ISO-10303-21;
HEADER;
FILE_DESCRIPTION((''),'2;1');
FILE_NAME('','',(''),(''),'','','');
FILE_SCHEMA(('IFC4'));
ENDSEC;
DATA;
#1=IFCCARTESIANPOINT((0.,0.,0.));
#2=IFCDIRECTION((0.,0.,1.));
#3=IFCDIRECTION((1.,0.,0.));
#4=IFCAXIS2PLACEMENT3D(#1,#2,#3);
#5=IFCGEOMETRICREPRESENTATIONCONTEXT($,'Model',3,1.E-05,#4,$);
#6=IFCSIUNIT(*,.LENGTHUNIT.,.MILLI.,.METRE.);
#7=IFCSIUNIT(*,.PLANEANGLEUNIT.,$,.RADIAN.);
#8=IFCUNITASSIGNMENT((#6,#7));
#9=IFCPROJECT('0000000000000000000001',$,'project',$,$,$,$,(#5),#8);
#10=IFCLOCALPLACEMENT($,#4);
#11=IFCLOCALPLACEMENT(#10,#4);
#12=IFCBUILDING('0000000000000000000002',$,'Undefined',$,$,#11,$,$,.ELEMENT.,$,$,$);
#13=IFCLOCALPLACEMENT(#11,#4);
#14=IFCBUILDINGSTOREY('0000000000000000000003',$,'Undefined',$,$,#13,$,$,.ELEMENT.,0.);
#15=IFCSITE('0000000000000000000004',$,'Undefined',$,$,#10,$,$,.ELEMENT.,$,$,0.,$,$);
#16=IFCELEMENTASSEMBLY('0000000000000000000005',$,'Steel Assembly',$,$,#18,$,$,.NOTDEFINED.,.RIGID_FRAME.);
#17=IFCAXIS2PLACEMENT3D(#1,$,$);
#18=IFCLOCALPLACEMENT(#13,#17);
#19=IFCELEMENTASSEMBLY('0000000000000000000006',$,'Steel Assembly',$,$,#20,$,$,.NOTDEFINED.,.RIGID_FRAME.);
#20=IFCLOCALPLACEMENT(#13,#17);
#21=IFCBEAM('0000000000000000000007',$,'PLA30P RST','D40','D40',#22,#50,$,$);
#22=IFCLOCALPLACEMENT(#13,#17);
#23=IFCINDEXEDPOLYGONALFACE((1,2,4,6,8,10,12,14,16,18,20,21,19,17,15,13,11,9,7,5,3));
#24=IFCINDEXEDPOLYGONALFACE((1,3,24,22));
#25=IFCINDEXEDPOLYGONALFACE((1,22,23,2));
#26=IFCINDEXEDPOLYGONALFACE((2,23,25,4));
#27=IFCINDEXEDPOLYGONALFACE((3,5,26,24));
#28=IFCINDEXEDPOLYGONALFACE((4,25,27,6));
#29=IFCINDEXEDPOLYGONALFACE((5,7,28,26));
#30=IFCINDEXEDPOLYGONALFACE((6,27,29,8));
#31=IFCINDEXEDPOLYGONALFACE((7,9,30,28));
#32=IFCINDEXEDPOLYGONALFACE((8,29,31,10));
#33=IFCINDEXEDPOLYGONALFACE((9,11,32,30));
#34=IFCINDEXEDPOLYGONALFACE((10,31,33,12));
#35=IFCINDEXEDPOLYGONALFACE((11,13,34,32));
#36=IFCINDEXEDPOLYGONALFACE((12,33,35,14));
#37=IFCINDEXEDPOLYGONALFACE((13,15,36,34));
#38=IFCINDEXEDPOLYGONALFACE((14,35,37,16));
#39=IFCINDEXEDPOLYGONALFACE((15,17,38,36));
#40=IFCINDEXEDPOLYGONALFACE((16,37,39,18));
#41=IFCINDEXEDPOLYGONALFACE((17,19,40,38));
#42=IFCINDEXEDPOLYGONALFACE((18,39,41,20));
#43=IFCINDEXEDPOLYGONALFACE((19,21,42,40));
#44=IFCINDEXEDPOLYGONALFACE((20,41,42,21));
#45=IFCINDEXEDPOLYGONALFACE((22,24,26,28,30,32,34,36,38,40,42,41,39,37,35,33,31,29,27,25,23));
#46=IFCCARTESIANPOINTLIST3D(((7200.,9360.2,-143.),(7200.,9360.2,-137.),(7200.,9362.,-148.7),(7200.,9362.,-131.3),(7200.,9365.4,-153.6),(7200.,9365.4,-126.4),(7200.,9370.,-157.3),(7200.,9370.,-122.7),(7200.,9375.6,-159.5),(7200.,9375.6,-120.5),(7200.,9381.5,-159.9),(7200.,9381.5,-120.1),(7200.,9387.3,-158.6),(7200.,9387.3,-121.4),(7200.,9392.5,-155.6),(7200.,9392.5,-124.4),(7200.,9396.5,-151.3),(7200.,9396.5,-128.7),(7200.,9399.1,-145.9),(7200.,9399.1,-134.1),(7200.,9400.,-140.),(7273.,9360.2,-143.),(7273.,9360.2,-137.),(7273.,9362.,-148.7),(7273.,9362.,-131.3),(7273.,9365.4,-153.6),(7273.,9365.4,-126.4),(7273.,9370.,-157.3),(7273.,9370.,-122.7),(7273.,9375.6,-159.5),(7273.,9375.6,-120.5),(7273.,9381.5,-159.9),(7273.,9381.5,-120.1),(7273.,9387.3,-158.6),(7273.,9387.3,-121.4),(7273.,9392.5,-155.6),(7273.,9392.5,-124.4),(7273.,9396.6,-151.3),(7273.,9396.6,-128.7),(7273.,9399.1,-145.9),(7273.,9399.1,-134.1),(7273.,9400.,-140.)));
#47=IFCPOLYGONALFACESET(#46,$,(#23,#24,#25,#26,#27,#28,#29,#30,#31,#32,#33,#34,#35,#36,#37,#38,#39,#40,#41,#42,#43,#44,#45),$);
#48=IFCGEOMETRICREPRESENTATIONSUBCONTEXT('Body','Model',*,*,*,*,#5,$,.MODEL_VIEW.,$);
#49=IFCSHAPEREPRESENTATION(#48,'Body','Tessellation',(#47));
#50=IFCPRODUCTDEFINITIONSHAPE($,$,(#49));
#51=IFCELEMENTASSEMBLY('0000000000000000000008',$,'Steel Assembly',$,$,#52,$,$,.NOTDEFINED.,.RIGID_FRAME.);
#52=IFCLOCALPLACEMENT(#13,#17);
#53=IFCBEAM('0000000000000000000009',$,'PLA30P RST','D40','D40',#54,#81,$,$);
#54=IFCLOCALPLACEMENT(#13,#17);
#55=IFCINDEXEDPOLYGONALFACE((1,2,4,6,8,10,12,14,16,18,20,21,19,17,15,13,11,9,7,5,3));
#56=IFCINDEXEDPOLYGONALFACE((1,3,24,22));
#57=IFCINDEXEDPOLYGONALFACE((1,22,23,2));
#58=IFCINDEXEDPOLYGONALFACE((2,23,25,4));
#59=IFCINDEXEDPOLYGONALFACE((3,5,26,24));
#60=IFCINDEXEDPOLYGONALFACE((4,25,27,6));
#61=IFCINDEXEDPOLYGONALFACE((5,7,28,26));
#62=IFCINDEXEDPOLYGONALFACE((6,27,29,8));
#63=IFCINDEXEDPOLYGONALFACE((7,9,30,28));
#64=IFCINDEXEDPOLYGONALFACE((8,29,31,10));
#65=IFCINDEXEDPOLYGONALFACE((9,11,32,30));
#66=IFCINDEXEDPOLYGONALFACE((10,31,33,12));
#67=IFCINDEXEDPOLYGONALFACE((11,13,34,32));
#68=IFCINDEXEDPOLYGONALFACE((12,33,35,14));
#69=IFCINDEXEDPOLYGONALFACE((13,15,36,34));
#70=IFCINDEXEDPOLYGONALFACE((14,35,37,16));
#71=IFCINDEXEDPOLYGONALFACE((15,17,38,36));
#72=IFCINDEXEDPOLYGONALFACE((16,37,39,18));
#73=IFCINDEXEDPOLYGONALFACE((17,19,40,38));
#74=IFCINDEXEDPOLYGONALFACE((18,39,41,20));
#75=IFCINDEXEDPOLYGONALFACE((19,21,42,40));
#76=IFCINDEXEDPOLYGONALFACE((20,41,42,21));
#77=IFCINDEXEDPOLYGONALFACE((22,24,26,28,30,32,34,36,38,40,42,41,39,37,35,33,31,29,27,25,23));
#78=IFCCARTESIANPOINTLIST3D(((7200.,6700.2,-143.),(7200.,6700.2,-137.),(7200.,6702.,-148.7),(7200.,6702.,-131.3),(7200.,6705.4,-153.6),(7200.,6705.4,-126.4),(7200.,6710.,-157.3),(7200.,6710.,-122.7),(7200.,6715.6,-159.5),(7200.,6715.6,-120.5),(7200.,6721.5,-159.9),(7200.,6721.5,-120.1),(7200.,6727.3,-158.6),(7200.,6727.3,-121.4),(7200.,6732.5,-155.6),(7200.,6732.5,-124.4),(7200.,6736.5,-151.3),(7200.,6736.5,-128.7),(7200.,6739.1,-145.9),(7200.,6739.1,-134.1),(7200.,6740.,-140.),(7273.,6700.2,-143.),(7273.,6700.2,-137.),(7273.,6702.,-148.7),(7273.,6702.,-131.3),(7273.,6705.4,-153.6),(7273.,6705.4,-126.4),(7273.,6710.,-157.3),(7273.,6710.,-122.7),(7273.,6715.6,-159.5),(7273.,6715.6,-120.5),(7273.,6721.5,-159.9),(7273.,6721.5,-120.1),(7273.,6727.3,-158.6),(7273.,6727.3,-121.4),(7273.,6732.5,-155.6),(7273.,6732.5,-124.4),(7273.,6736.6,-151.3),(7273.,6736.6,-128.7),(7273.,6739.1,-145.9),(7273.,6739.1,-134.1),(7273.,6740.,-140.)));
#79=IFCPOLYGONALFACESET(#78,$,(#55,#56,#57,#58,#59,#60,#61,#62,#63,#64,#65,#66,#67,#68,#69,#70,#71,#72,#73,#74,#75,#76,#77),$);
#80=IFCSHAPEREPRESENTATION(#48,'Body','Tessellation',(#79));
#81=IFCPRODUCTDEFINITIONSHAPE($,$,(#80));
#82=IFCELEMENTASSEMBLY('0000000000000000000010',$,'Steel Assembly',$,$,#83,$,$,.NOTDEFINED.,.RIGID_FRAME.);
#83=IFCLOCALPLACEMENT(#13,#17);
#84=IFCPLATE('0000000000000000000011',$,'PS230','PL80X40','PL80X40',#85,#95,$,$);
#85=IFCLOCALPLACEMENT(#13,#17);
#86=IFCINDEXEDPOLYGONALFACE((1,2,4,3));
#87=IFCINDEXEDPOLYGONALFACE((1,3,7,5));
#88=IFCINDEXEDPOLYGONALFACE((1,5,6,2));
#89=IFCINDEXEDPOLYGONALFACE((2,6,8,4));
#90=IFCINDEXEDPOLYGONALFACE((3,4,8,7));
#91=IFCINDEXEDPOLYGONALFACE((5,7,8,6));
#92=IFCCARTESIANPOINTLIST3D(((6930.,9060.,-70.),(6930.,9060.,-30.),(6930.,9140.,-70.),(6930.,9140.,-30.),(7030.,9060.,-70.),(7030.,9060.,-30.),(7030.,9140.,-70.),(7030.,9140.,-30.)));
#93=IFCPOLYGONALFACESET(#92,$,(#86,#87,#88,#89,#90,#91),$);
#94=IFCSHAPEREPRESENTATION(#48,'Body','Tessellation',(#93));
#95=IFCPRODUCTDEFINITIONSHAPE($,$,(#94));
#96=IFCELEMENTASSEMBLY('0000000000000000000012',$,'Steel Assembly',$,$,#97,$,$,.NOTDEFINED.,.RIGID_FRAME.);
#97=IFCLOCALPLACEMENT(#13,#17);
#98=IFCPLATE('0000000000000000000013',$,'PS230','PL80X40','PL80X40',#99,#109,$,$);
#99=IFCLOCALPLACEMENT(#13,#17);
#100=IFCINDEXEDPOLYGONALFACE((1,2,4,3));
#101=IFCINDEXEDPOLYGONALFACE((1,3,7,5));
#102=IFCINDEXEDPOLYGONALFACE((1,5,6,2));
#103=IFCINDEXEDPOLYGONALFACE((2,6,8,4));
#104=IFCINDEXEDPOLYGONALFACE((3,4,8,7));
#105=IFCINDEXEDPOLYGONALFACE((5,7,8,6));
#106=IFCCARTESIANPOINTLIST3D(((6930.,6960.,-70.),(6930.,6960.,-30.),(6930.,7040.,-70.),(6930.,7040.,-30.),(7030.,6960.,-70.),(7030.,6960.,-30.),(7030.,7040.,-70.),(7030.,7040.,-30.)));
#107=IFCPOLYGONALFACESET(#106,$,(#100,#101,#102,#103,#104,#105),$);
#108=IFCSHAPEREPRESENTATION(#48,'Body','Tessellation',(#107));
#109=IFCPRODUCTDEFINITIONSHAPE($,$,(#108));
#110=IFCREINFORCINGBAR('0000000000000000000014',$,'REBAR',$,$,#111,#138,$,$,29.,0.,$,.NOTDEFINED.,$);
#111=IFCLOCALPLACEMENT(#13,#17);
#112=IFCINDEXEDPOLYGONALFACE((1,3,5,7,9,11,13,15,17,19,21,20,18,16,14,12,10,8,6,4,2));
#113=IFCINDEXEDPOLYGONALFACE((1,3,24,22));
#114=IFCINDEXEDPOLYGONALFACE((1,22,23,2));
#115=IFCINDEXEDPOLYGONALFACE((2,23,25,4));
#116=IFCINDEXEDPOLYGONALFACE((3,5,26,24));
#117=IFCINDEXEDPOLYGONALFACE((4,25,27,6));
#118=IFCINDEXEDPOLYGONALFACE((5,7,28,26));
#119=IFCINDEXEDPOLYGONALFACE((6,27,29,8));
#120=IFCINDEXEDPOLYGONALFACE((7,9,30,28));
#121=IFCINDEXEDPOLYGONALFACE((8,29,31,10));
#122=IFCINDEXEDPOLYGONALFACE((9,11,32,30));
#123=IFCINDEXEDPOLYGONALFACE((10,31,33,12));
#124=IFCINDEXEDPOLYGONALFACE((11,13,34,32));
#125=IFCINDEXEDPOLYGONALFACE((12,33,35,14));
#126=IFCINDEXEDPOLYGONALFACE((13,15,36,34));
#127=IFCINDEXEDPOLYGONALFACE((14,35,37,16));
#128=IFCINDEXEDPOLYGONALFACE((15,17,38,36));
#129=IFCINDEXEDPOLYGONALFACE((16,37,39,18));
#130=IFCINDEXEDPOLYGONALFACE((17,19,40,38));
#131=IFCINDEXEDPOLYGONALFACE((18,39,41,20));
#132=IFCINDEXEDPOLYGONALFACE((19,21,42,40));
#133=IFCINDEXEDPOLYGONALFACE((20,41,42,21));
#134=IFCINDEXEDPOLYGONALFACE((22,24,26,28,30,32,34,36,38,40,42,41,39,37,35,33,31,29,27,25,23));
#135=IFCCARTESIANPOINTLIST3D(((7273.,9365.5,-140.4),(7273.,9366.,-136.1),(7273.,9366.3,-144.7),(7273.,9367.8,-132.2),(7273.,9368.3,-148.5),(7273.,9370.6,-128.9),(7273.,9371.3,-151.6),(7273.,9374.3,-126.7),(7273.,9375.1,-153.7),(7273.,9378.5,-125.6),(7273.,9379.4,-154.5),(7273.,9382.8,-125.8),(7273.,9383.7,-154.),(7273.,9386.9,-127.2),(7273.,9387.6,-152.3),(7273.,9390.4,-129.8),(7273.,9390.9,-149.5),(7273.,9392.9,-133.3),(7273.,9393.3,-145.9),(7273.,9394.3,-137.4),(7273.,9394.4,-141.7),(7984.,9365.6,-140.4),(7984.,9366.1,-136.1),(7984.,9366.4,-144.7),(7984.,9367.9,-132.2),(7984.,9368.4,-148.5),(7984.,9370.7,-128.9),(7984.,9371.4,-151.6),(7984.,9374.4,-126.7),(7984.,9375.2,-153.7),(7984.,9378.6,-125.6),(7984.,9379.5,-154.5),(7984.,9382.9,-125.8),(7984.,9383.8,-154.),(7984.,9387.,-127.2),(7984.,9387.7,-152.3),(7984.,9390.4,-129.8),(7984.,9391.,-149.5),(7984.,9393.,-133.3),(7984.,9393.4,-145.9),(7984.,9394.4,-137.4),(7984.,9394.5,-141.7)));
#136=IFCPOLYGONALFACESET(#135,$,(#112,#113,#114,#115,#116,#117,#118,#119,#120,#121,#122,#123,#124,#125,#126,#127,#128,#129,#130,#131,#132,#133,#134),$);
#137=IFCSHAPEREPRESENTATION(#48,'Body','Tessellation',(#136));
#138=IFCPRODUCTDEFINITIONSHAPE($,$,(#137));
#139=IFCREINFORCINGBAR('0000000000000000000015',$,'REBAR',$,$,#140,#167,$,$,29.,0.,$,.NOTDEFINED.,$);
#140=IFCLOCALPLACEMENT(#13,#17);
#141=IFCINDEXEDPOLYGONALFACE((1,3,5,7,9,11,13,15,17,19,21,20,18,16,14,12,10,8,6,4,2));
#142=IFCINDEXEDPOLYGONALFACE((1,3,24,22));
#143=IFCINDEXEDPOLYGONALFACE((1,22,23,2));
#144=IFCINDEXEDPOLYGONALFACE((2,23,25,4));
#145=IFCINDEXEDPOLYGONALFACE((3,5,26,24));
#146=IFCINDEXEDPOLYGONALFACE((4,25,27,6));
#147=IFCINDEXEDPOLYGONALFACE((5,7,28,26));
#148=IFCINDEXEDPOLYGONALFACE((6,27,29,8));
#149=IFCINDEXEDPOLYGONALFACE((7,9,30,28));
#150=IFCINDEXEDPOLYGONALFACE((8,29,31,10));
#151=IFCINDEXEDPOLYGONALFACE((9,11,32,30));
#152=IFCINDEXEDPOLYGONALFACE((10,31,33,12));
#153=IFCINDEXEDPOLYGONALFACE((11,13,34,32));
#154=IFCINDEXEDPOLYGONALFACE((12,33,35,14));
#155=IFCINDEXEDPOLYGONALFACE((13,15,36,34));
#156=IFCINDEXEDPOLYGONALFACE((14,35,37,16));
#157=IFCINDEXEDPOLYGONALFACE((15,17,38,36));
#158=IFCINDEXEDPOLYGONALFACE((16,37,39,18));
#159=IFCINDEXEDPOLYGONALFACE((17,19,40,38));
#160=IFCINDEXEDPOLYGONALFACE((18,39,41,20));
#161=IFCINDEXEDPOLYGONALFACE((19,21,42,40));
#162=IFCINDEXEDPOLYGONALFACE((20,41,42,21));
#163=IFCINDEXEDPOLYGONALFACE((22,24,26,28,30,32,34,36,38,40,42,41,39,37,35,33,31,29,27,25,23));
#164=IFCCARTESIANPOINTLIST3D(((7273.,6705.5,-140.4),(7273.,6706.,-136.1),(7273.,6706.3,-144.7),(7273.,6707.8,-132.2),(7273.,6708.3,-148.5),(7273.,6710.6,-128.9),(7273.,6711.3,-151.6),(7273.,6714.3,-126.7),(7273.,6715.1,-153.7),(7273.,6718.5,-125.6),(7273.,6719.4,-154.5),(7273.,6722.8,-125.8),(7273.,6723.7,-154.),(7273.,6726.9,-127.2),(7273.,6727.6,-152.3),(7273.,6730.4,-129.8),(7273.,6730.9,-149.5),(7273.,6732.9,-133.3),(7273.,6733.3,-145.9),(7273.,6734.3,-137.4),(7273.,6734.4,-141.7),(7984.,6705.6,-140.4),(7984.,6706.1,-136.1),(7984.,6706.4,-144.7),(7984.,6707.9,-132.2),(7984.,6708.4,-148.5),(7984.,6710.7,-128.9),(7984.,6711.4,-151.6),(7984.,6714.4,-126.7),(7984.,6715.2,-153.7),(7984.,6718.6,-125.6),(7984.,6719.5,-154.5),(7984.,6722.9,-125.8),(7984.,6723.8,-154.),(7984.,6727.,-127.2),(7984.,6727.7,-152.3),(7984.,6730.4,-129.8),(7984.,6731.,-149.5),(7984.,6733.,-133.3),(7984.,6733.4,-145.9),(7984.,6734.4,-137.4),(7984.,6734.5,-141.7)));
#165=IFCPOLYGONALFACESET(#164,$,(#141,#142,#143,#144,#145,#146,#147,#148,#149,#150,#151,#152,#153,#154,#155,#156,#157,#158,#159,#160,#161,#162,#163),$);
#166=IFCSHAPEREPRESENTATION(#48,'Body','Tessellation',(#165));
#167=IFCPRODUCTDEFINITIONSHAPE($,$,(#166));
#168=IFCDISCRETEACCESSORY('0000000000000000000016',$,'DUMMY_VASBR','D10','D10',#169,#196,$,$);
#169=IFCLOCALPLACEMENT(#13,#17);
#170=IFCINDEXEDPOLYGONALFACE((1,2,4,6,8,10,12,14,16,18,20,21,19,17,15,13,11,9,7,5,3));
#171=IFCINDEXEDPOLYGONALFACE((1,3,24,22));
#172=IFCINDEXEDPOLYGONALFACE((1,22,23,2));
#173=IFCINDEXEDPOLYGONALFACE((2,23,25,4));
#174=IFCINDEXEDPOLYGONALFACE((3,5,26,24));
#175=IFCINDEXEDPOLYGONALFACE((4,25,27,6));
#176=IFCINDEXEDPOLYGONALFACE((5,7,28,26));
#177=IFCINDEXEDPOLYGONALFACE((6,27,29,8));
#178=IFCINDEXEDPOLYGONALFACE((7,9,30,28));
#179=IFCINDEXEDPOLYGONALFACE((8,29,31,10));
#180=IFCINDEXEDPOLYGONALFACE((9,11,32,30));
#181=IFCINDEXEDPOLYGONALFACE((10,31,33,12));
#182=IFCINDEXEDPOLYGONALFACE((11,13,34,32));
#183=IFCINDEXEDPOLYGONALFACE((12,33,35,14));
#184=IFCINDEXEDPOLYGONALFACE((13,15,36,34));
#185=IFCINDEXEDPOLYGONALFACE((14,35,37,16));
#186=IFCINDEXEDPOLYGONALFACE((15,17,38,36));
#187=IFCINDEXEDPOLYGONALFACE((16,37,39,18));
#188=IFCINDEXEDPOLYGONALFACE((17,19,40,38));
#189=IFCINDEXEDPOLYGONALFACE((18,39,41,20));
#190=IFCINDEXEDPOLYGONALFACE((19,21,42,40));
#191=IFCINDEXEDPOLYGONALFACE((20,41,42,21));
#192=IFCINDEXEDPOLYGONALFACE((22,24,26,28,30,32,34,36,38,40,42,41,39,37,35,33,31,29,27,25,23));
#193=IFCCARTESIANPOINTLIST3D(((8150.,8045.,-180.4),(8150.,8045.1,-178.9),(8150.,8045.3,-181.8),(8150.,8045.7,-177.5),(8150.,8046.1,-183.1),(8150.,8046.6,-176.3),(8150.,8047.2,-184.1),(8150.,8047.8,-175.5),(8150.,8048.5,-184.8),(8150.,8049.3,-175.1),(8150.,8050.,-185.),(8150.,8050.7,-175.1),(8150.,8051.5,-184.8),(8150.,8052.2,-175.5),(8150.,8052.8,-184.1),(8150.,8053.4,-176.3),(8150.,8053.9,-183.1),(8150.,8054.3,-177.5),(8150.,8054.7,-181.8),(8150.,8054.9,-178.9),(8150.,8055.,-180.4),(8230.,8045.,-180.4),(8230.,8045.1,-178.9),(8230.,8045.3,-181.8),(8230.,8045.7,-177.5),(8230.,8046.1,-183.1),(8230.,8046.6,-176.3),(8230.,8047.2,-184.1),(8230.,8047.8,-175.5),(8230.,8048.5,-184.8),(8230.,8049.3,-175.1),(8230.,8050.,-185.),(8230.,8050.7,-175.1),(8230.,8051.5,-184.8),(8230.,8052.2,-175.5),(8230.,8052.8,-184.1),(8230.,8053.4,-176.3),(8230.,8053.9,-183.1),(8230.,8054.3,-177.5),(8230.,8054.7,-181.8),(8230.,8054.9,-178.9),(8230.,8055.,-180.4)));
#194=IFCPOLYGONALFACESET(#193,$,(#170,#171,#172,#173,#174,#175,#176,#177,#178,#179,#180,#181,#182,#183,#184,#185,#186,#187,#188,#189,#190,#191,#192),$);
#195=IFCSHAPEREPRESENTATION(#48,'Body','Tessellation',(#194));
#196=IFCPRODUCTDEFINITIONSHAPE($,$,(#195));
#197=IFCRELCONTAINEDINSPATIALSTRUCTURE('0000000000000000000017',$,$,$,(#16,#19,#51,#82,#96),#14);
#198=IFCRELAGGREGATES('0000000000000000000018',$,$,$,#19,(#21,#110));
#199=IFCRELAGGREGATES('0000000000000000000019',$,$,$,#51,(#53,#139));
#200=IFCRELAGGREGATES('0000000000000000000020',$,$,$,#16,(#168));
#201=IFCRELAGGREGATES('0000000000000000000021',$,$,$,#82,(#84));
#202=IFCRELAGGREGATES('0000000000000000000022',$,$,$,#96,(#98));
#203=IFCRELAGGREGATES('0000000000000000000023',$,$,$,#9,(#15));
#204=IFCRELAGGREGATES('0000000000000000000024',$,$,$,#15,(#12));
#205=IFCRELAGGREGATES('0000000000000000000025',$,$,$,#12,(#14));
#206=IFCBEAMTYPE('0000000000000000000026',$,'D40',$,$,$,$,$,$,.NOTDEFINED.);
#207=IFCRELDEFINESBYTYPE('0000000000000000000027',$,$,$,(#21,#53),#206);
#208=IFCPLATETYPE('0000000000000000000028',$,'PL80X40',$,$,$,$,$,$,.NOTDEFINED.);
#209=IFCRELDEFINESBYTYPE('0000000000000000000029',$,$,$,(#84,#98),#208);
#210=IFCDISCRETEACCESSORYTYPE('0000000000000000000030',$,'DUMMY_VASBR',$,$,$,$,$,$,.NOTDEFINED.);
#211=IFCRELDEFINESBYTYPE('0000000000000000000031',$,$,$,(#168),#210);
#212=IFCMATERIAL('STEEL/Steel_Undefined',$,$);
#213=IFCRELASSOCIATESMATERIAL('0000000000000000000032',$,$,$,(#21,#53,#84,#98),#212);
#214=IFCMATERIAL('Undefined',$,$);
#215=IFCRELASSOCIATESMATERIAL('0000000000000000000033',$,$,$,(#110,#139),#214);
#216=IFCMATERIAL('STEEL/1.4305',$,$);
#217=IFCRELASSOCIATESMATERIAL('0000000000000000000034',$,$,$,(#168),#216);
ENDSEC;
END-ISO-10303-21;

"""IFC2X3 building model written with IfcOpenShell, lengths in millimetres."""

from ifc_helpers import new_model, entity, si_unit, frame, origin_with_axes, origin_2d_with_axis, place, context, subcontext, project, spatial, polyline, circle, outline, extrude, source, transform, mapped, material, type_object, element, aggregate, save


model = new_model("IFC2X3")

# Units and contexts
model_context = context("Model", 3, precision=1e-05, world=origin_with_axes())
body_context = subcontext(model_context, "Body", "Model", "MODEL_VIEW")
ifc_project = project(units=[si_unit("LENGTHUNIT", "METRE", prefix="MILLI"), si_unit("PLANEANGLEUNIT", "RADIAN")], contexts=[model_context])

# Site, building, storey
site_placement = place(None, origin_with_axes())
site = spatial("IfcSite", under=ifc_project, at=site_placement, Name="Undefined", CompositionType="ELEMENT", RefElevation=0.0)
building_placement = place(site_placement, origin_with_axes())
building = spatial("IfcBuilding", under=site, at=building_placement, Name="Undefined", CompositionType="ELEMENT")
storey_placement = place(building_placement, origin_with_axes())
storey = spatial("IfcBuildingStorey", under=building, at=storey_placement, Name="Undefined", CompositionType="ELEMENT", Elevation=0.0)

# Element assembly
ifc_material_1 = material(Name="STEEL/Steel_Undefined")
assembly_1_placement = place(storey_placement, origin_with_axes())
assembly_1 = element("IfcElementAssembly", 1, at=assembly_1_placement, inside=storey, Name="Steel Assembly", AssemblyPlace="NOTDEFINED", PredefinedType="RIGID_FRAME")
ifc_material_2 = material(Name="STEEL/1.4305")

# Element assemblies, beams
assembly_2_placement = place(storey_placement, origin_with_axes())
assembly_2 = element("IfcElementAssembly", 2, at=assembly_2_placement, inside=storey, Name="Steel Assembly", AssemblyPlace="NOTDEFINED", PredefinedType="RIGID_FRAME")
beam_type = type_object("IfcBeamType", Name="D40", PredefinedType="NOTDEFINED")
beam_1_placement = place(assembly_2_placement, frame((7273.0, 9380.0, -140.0), z_axis=(0.000001, 0.000003, 1.0), x_axis=(-1.0, -0.00013, 0.000001)))
beam_1 = element("IfcBeam", 3, at=beam_1_placement, type_object=beam_type, material=ifc_material_1, Name="PLA30P RST", Description="D40", ObjectType="D40", context=body_context, shape_type="SweptSolid", body=[
    extrude(circle(Radius=20.0, at=origin_2d_with_axis()), frame((73.0, 0.0, 0.0), z_axis=(-1.0, 0.0, 0.0), x_axis=(0.0, -1.0, 0.0)), (0.0, 0.0, 1.0), 73.0),
])
assembly_3_placement = place(storey_placement, origin_with_axes())
assembly_3 = element("IfcElementAssembly", 4, at=assembly_3_placement, inside=storey, Name="Steel Assembly", AssemblyPlace="NOTDEFINED", PredefinedType="RIGID_FRAME")
beam_2_placement = place(assembly_3_placement, frame((7273.0, 6720.0, -140.0), z_axis=(0.000001, 0.000003, 1.0), x_axis=(-1.0, -0.00013, 0.000001)))
beam_2 = element("IfcBeam", 5, at=beam_2_placement, type_object=beam_type, material=ifc_material_1, Name="PLA30P RST", Description="D40", ObjectType="D40", context=body_context, shape_type="SweptSolid", body=[
    extrude(circle(Radius=20.0, at=origin_2d_with_axis()), frame((73.0, 0.0, 0.0), z_axis=(-1.0, 0.0, 0.0), x_axis=(0.0, -1.0, 0.0)), (0.0, 0.0, 1.0), 73.0),
])

# Element assemblies, plates
assembly_4_placement = place(storey_placement, origin_with_axes())
assembly_4 = element("IfcElementAssembly", 6, at=assembly_4_placement, inside=storey, Name="Steel Assembly", AssemblyPlace="NOTDEFINED", PredefinedType="RIGID_FRAME")
plate_type = type_object("IfcPlateType", Name="PL80X40", PredefinedType="NOTDEFINED")
plate_1_placement = place(assembly_4_placement, frame((7030.0, 9100.0, -70.0), z_axis=(0.0, -1.0, 0.0), x_axis=(0.0, 0.0, 1.0)))
plate_1 = element("IfcPlate", 7, at=plate_1_placement, type_object=plate_type, material=ifc_material_1, Name="PS230", Description="PL80X40", ObjectType="PL80X40", context=body_context, shape_type="SweptSolid", body=[
    extrude(outline(polyline([(0.0, 0.0), (40.0, 0.0), (40.0, 100.0), (0.0, 100.0), (0.0, 0.0)])), frame((0.0, 0.0, -40.0), z_axis=(0.0, 0.0, 1.0), x_axis=(1.0, 0.0, 0.0)), (0.0, 0.0, 1.0), 80.0),
])
assembly_5_placement = place(storey_placement, origin_with_axes())
assembly_5 = element("IfcElementAssembly", 8, at=assembly_5_placement, inside=storey, Name="Steel Assembly", AssemblyPlace="NOTDEFINED", PredefinedType="RIGID_FRAME")
plate_2_placement = place(assembly_5_placement, frame((7030.0, 7000.0, -70.0), z_axis=(0.0, -1.0, 0.0), x_axis=(0.0, 0.0, 1.0)))
plate_2 = element("IfcPlate", 9, at=plate_2_placement, type_object=plate_type, material=ifc_material_1, Name="PS230", Description="PL80X40", ObjectType="PL80X40", context=body_context, shape_type="SweptSolid", body=[
    extrude(outline(polyline([(0.0, 0.0), (40.0, 0.0), (40.0, 100.0), (0.0, 100.0), (0.0, 0.0)])), frame((0.0, 0.0, -40.0), z_axis=(0.0, 0.0, 1.0), x_axis=(1.0, 0.0, 0.0)), (0.0, 0.0, 1.0), 80.0),
])

# Reinforcing bars
ifc_material_3 = material(Name="Undefined")
shared_shape_1 = source(origin_with_axes(), body_context, "Body", "AdvancedSweptSolid", [
    entity("IfcSweptDiskSolid", entity("IfcTrimmedCurve", entity("IfcLine", entity("IfcCartesianPoint", [0.0, 0.0, 0.0]), entity("IfcVector", entity("IfcDirection", [1.0, 0.0, 0.0]), 1.0)), [entity("IfcParameterValue", 0.0)], [entity("IfcParameterValue", 711.0)], True, "PARAMETER"), 14.5, None, 0.0, 711.0),
])
reinforcing_bar_1_placement = place(assembly_2_placement, frame((7273.0, 9380.0, -140.0), z_axis=(0.00013, -0.999549, -0.030038), x_axis=(1.0, 0.00013, -0.000001)))
reinforcing_bar_1 = element("IfcReinforcingBar", 10, at=reinforcing_bar_1_placement, material=ifc_material_3, Name="REBAR", BarRole="NOTDEFINED", CrossSectionArea=0.0, NominalDiameter=29.0, context=body_context, shape_type="MappedRepresentation", body=[
    mapped(shared_shape_1, transform((0.0, 0.0, 0.0))),
])
aggregate(assembly_2, [beam_1, reinforcing_bar_1])
shared_shape_2 = source(origin_with_axes(), body_context, "Body", "AdvancedSweptSolid", [
    entity("IfcSweptDiskSolid", entity("IfcTrimmedCurve", entity("IfcLine", entity("IfcCartesianPoint", [0.0, 0.0, 0.0]), entity("IfcVector", entity("IfcDirection", [1.0, 0.0, 0.0]), 1.0)), [entity("IfcParameterValue", 0.0)], [entity("IfcParameterValue", 711.0)], True, "PARAMETER"), 14.5, None, 0.0, 711.0),
])
reinforcing_bar_2_placement = place(assembly_3_placement, frame((7273.0, 6720.0, -140.0), z_axis=(0.00013, -0.999549, -0.030038), x_axis=(1.0, 0.00013, -0.000001)))
reinforcing_bar_2 = element("IfcReinforcingBar", 11, at=reinforcing_bar_2_placement, material=ifc_material_3, Name="REBAR", BarRole="NOTDEFINED", CrossSectionArea=0.0, NominalDiameter=29.0, context=body_context, shape_type="MappedRepresentation", body=[
    mapped(shared_shape_2, transform((0.0, 0.0, 0.0))),
])
aggregate(assembly_3, [beam_2, reinforcing_bar_2])

# Discrete accessory
discrete_accessory_type_1 = type_object("IfcDiscreteAccessoryType", Name="DUMMY_VASBR")
discrete_accessory_1_placement = place(assembly_1_placement, frame((8230.0, 8050.0, -180.0), z_axis=(0.0, 1.0, 0.0), x_axis=(-1.0, 0.0, 0.0)))
discrete_accessory_1 = element("IfcDiscreteAccessory", 12, at=discrete_accessory_1_placement, type_object=discrete_accessory_type_1, material=ifc_material_2, Name="DUMMY_VASBR", Description="D10", ObjectType="D10", context=body_context, shape_type="SweptSolid", body=[
    extrude(circle(Radius=5.0, at=origin_2d_with_axis()), frame((80.0, 0.0, 0.0), z_axis=(-1.0, 0.0, 0.0), x_axis=(0.0, -1.0, 0.0)), (0.0, 0.0, 1.0), 80.0),
])
aggregate(assembly_1, [discrete_accessory_1])

aggregate(assembly_4, [plate_1])
aggregate(assembly_5, [plate_2])

save(model, "model.ifc")
